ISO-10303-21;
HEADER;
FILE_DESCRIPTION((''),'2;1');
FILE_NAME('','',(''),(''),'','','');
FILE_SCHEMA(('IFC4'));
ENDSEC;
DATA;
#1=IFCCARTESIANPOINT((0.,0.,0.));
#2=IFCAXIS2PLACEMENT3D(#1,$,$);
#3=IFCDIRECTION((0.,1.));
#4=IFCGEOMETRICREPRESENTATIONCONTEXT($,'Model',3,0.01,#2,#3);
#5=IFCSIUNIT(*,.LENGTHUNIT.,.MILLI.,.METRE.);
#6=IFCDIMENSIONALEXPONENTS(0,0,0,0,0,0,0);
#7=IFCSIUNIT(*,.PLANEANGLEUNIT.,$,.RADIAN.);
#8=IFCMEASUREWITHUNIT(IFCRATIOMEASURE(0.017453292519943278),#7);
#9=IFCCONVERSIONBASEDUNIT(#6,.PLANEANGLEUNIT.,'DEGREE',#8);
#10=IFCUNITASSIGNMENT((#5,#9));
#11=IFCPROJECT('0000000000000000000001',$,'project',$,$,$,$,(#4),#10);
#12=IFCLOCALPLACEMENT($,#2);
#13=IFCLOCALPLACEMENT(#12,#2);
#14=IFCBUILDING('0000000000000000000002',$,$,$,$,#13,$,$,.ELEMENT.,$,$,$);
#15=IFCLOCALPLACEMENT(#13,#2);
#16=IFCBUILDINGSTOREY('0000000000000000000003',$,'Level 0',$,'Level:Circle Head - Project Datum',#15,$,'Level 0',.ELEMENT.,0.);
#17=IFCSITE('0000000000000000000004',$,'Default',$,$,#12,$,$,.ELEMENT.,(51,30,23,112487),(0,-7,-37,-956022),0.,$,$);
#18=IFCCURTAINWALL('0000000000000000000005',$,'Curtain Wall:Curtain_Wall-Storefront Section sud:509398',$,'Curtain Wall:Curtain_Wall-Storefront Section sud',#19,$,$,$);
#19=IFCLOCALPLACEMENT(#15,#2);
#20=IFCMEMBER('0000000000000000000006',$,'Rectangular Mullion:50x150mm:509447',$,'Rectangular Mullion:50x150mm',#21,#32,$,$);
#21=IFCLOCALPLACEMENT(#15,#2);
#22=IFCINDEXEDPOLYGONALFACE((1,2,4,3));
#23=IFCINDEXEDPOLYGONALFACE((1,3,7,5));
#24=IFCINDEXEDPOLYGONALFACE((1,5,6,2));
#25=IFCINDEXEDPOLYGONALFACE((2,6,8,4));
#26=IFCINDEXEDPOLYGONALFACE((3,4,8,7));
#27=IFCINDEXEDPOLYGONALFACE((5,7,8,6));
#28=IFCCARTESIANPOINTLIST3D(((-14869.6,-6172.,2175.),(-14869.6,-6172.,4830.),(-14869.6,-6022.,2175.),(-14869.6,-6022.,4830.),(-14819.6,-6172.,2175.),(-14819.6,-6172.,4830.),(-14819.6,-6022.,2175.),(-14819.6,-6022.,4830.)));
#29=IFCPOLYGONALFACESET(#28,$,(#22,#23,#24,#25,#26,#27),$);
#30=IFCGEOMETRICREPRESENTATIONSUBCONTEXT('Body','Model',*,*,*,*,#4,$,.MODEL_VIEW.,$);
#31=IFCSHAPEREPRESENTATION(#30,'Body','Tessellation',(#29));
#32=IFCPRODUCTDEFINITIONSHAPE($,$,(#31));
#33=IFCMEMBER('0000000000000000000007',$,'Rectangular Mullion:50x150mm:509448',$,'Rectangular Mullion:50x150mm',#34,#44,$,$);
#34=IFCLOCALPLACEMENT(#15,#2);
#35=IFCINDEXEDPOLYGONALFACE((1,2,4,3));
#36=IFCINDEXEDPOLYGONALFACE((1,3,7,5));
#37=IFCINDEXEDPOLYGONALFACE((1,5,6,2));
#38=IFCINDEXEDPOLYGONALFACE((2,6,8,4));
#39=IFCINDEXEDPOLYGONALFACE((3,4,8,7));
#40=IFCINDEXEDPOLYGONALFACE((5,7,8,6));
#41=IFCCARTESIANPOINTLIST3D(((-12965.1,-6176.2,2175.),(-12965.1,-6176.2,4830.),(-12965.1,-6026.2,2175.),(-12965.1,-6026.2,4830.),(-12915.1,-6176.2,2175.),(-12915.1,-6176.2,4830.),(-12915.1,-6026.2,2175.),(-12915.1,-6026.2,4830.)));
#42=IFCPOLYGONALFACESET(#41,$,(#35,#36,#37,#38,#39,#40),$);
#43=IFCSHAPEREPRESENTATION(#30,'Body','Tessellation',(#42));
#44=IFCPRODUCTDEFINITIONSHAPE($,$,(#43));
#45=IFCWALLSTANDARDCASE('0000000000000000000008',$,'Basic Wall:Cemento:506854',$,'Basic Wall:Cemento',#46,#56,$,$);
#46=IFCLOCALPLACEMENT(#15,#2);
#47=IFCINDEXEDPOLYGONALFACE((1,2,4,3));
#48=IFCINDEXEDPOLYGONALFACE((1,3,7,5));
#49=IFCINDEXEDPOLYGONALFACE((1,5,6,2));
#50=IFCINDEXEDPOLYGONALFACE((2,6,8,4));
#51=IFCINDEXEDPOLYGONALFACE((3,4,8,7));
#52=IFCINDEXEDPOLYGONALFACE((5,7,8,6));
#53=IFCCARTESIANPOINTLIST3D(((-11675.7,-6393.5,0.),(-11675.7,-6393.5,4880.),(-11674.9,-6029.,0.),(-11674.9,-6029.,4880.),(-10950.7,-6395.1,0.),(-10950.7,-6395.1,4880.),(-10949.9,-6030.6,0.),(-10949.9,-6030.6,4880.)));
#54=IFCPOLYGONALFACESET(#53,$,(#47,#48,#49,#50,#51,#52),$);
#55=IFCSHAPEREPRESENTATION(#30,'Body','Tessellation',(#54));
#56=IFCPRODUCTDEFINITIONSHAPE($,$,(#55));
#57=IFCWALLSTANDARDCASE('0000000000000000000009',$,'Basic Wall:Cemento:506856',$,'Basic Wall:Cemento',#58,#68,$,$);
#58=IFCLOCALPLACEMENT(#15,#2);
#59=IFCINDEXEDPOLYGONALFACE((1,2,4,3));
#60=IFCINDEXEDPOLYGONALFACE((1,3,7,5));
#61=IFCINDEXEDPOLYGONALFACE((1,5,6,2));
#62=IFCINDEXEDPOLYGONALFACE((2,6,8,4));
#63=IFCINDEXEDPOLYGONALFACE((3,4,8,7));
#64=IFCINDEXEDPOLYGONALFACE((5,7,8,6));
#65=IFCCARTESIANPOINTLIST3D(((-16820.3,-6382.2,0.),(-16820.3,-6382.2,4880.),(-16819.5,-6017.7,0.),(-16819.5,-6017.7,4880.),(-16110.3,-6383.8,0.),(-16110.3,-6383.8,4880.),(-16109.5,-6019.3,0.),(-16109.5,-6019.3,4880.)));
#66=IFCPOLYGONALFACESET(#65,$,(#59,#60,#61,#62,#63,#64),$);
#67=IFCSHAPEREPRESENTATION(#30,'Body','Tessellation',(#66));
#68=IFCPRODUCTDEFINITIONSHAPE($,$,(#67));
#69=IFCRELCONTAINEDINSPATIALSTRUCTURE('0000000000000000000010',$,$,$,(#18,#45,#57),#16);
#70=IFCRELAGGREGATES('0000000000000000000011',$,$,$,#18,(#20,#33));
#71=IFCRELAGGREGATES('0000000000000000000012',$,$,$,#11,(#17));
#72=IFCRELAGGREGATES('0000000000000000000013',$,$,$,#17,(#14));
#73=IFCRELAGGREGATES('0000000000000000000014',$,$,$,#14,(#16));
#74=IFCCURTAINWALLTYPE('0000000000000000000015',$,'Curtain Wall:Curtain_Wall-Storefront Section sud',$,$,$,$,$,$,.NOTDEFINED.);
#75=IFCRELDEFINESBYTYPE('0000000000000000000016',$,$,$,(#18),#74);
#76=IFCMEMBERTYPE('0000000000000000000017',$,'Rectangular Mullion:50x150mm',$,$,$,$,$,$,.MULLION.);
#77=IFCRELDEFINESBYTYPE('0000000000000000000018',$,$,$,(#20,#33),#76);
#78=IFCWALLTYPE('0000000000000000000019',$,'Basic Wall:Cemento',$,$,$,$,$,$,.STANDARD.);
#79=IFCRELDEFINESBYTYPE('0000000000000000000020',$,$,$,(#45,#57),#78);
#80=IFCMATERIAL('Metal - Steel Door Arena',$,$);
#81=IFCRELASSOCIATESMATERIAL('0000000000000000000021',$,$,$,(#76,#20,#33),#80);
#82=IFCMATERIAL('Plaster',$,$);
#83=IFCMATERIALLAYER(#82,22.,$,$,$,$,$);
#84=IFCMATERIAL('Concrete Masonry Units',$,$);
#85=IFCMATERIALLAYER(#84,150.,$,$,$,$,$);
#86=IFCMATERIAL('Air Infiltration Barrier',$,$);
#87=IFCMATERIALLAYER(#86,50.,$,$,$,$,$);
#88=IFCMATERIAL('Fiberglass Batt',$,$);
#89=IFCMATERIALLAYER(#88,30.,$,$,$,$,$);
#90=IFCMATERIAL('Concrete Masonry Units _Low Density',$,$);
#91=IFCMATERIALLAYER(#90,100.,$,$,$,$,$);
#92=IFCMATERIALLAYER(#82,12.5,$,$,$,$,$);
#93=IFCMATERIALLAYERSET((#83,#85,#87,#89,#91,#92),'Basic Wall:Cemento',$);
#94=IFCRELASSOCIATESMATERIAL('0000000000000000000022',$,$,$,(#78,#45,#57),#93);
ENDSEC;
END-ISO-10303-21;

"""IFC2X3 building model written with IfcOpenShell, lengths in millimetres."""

from ifc_helpers import new_model, entity, si_unit, converted_unit, direction, frame, frame_2d, origin, origin_2d_with_axis, place, context, subcontext, project, spatial, rectangle, extrude, source, transform, mapped, material, layer, layer_set, layer_usage, type_object, type_shapes, element, aggregate, save


model = new_model("IFC2X3")

# Units and contexts
model_context = context("Model", 3, precision=0.01, world=origin(), true_north=direction((0.0, 1.0)))
body_context = subcontext(model_context, "Body", "Model", "MODEL_VIEW")
ifc_project = project(units=[si_unit("LENGTHUNIT", "METRE", prefix="MILLI"), converted_unit("PLANEANGLEUNIT", "DEGREE", entity("IfcRatioMeasure", 0.017453292519943278), si_unit("PLANEANGLEUNIT", "RADIAN"), dimensions=[0, 0, 0, 0, 0, 0, 0])], contexts=[model_context])

# Site, building, storey
site_placement = place(None, origin())
site = spatial("IfcSite", under=ifc_project, at=site_placement, Name="Default", CompositionType="ELEMENT", RefLatitude=(51, 30, 23, 112487), RefLongitude=(0, -7, -37, -956022), RefElevation=0.0)
building_placement = place(site_placement, origin())
building = spatial("IfcBuilding", under=site, at=building_placement, CompositionType="ELEMENT")
storey_placement = place(building_placement, origin())
storey = spatial("IfcBuildingStorey", under=building, at=storey_placement, Name="Level 0", ObjectType="Level:Circle Head - Project Datum", LongName="Level 0", CompositionType="ELEMENT", Elevation=0.0)

# Curtain wall, members
curtain_wall_type = type_object("IfcCurtainWallType", Name="Curtain Wall:Curtain_Wall-Storefront Section sud", PredefinedType="NOTDEFINED")
curtain_wall_placement = place(storey_placement, origin())
curtain_wall = element("IfcCurtainWall", 1, at=curtain_wall_placement, inside=storey, type_object=curtain_wall_type, Name="Curtain Wall:Curtain_Wall-Storefront Section sud:509398", ObjectType="Curtain Wall:Curtain_Wall-Storefront Section sud")
ifc_material_1 = material(Name="Metal - Steel Door Arena")
member_type_1 = type_object("IfcMemberType", Name="Rectangular Mullion:50x150mm", PredefinedType="MULLION", material=ifc_material_1)
shared_shape_1 = source(origin(), body_context, "Body", "SweptSolid", [
    extrude(rectangle(XDim=150.0, YDim=50.0, at=origin_2d_with_axis()), frame((0.0, 0.0, -2655.0), z_axis=(0.0, 0.0, 1.0), x_axis=(0.0, -1.0, 0.0)), (0.0, 0.0, 1.0), 2655.0),
])
type_shapes(member_type_1, [shared_shape_1])
member_1_placement = place(curtain_wall_placement, frame((-14844.6, -6097.0, 2175.0), z_axis=(0.0, 0.0, -1.0), x_axis=(1.0, 0.0, 0.0)))
member_1 = element("IfcMember", 2, at=member_1_placement, type_object=member_type_1, material=ifc_material_1, Name="Rectangular Mullion:50x150mm:509447", ObjectType="Rectangular Mullion:50x150mm", context=body_context, shape_type="MappedRepresentation", body=[
    mapped(shared_shape_1, transform((0.0, 0.0, 0.0), scale=1.0)),
])
member_2_placement = place(curtain_wall_placement, frame((-12940.1, -6101.2, 2175.0), z_axis=(0.0, 0.0, -1.0), x_axis=(1.0, 0.0, 0.0)))
member_2 = element("IfcMember", 3, at=member_2_placement, type_object=member_type_1, material=ifc_material_1, Name="Rectangular Mullion:50x150mm:509448", ObjectType="Rectangular Mullion:50x150mm", context=body_context, shape_type="MappedRepresentation", body=[
    mapped(shared_shape_1, transform((0.0, 0.0, 0.0), scale=1.0)),
])
aggregate(curtain_wall, [member_1, member_2])

# Walls
ifc_material_2 = material(Name="Plaster")
ifc_material_3 = material(Name="Concrete Masonry Units")
ifc_layer_1 = layer(ifc_material_2, 22.0)
ifc_layer_2 = layer(ifc_material_3, 150.0)
ifc_material_4 = material(Name="Air Infiltration Barrier")
ifc_layer_3 = layer(ifc_material_4, 50.0)
ifc_material_5 = material(Name="Fiberglass Batt")
ifc_layer_4 = layer(ifc_material_5, 30.0)
ifc_material_6 = material(Name="Concrete Masonry Units _Low Density")
ifc_layer_5 = layer(ifc_material_6, 100.0)
ifc_layer_6 = layer(ifc_material_2, 12.5)
ifc_layer_set_1 = layer_set([ifc_layer_1, ifc_layer_2, ifc_layer_3, ifc_layer_4, ifc_layer_5, ifc_layer_6], Name="Basic Wall:Cemento")
ifc_layer_usage_1 = layer_usage(ifc_layer_set_1, "AXIS2", "NEGATIVE", 182.3)
wall_type_1 = type_object("IfcWallType", Name="Basic Wall:Cemento", PredefinedType="STANDARD", material=ifc_layer_set_1)
wall_1_placement = place(storey_placement, frame((-10950.3, -6212.9, 0.0), z_axis=(0.0, 0.0, 1.0), x_axis=(-0.999998, 0.002199, 0.0)))
element("IfcWallStandardCase", 4, at=wall_1_placement, inside=storey, type_object=wall_type_1, material=ifc_layer_usage_1, Name="Basic Wall:Cemento:506854", ObjectType="Basic Wall:Cemento", context=body_context, shape_type="SweptSolid", body=[
    extrude(rectangle(XDim=725.0, YDim=364.5, at=frame_2d((362.5, 0.0), x_axis=(-1.0, 0.0))), origin(), (0.0, 0.0, 1.0), 4880.0),
])
ifc_layer_usage_2 = layer_usage(ifc_layer_set_1, "AXIS2", "NEGATIVE", 182.3)
wall_2_placement = place(storey_placement, frame((-16109.9, -6201.5, 0.0), z_axis=(0.0, 0.0, 1.0), x_axis=(-0.999998, 0.002199, 0.0)))
element("IfcWallStandardCase", 5, at=wall_2_placement, inside=storey, type_object=wall_type_1, material=ifc_layer_usage_2, Name="Basic Wall:Cemento:506856", ObjectType="Basic Wall:Cemento", context=body_context, shape_type="SweptSolid", body=[
    extrude(rectangle(XDim=710.0, YDim=364.5, at=frame_2d((355.0, 0.0), x_axis=(-1.0, 0.0))), origin(), (0.0, 0.0, 1.0), 4880.0),
])

save(model, "model.ifc")
